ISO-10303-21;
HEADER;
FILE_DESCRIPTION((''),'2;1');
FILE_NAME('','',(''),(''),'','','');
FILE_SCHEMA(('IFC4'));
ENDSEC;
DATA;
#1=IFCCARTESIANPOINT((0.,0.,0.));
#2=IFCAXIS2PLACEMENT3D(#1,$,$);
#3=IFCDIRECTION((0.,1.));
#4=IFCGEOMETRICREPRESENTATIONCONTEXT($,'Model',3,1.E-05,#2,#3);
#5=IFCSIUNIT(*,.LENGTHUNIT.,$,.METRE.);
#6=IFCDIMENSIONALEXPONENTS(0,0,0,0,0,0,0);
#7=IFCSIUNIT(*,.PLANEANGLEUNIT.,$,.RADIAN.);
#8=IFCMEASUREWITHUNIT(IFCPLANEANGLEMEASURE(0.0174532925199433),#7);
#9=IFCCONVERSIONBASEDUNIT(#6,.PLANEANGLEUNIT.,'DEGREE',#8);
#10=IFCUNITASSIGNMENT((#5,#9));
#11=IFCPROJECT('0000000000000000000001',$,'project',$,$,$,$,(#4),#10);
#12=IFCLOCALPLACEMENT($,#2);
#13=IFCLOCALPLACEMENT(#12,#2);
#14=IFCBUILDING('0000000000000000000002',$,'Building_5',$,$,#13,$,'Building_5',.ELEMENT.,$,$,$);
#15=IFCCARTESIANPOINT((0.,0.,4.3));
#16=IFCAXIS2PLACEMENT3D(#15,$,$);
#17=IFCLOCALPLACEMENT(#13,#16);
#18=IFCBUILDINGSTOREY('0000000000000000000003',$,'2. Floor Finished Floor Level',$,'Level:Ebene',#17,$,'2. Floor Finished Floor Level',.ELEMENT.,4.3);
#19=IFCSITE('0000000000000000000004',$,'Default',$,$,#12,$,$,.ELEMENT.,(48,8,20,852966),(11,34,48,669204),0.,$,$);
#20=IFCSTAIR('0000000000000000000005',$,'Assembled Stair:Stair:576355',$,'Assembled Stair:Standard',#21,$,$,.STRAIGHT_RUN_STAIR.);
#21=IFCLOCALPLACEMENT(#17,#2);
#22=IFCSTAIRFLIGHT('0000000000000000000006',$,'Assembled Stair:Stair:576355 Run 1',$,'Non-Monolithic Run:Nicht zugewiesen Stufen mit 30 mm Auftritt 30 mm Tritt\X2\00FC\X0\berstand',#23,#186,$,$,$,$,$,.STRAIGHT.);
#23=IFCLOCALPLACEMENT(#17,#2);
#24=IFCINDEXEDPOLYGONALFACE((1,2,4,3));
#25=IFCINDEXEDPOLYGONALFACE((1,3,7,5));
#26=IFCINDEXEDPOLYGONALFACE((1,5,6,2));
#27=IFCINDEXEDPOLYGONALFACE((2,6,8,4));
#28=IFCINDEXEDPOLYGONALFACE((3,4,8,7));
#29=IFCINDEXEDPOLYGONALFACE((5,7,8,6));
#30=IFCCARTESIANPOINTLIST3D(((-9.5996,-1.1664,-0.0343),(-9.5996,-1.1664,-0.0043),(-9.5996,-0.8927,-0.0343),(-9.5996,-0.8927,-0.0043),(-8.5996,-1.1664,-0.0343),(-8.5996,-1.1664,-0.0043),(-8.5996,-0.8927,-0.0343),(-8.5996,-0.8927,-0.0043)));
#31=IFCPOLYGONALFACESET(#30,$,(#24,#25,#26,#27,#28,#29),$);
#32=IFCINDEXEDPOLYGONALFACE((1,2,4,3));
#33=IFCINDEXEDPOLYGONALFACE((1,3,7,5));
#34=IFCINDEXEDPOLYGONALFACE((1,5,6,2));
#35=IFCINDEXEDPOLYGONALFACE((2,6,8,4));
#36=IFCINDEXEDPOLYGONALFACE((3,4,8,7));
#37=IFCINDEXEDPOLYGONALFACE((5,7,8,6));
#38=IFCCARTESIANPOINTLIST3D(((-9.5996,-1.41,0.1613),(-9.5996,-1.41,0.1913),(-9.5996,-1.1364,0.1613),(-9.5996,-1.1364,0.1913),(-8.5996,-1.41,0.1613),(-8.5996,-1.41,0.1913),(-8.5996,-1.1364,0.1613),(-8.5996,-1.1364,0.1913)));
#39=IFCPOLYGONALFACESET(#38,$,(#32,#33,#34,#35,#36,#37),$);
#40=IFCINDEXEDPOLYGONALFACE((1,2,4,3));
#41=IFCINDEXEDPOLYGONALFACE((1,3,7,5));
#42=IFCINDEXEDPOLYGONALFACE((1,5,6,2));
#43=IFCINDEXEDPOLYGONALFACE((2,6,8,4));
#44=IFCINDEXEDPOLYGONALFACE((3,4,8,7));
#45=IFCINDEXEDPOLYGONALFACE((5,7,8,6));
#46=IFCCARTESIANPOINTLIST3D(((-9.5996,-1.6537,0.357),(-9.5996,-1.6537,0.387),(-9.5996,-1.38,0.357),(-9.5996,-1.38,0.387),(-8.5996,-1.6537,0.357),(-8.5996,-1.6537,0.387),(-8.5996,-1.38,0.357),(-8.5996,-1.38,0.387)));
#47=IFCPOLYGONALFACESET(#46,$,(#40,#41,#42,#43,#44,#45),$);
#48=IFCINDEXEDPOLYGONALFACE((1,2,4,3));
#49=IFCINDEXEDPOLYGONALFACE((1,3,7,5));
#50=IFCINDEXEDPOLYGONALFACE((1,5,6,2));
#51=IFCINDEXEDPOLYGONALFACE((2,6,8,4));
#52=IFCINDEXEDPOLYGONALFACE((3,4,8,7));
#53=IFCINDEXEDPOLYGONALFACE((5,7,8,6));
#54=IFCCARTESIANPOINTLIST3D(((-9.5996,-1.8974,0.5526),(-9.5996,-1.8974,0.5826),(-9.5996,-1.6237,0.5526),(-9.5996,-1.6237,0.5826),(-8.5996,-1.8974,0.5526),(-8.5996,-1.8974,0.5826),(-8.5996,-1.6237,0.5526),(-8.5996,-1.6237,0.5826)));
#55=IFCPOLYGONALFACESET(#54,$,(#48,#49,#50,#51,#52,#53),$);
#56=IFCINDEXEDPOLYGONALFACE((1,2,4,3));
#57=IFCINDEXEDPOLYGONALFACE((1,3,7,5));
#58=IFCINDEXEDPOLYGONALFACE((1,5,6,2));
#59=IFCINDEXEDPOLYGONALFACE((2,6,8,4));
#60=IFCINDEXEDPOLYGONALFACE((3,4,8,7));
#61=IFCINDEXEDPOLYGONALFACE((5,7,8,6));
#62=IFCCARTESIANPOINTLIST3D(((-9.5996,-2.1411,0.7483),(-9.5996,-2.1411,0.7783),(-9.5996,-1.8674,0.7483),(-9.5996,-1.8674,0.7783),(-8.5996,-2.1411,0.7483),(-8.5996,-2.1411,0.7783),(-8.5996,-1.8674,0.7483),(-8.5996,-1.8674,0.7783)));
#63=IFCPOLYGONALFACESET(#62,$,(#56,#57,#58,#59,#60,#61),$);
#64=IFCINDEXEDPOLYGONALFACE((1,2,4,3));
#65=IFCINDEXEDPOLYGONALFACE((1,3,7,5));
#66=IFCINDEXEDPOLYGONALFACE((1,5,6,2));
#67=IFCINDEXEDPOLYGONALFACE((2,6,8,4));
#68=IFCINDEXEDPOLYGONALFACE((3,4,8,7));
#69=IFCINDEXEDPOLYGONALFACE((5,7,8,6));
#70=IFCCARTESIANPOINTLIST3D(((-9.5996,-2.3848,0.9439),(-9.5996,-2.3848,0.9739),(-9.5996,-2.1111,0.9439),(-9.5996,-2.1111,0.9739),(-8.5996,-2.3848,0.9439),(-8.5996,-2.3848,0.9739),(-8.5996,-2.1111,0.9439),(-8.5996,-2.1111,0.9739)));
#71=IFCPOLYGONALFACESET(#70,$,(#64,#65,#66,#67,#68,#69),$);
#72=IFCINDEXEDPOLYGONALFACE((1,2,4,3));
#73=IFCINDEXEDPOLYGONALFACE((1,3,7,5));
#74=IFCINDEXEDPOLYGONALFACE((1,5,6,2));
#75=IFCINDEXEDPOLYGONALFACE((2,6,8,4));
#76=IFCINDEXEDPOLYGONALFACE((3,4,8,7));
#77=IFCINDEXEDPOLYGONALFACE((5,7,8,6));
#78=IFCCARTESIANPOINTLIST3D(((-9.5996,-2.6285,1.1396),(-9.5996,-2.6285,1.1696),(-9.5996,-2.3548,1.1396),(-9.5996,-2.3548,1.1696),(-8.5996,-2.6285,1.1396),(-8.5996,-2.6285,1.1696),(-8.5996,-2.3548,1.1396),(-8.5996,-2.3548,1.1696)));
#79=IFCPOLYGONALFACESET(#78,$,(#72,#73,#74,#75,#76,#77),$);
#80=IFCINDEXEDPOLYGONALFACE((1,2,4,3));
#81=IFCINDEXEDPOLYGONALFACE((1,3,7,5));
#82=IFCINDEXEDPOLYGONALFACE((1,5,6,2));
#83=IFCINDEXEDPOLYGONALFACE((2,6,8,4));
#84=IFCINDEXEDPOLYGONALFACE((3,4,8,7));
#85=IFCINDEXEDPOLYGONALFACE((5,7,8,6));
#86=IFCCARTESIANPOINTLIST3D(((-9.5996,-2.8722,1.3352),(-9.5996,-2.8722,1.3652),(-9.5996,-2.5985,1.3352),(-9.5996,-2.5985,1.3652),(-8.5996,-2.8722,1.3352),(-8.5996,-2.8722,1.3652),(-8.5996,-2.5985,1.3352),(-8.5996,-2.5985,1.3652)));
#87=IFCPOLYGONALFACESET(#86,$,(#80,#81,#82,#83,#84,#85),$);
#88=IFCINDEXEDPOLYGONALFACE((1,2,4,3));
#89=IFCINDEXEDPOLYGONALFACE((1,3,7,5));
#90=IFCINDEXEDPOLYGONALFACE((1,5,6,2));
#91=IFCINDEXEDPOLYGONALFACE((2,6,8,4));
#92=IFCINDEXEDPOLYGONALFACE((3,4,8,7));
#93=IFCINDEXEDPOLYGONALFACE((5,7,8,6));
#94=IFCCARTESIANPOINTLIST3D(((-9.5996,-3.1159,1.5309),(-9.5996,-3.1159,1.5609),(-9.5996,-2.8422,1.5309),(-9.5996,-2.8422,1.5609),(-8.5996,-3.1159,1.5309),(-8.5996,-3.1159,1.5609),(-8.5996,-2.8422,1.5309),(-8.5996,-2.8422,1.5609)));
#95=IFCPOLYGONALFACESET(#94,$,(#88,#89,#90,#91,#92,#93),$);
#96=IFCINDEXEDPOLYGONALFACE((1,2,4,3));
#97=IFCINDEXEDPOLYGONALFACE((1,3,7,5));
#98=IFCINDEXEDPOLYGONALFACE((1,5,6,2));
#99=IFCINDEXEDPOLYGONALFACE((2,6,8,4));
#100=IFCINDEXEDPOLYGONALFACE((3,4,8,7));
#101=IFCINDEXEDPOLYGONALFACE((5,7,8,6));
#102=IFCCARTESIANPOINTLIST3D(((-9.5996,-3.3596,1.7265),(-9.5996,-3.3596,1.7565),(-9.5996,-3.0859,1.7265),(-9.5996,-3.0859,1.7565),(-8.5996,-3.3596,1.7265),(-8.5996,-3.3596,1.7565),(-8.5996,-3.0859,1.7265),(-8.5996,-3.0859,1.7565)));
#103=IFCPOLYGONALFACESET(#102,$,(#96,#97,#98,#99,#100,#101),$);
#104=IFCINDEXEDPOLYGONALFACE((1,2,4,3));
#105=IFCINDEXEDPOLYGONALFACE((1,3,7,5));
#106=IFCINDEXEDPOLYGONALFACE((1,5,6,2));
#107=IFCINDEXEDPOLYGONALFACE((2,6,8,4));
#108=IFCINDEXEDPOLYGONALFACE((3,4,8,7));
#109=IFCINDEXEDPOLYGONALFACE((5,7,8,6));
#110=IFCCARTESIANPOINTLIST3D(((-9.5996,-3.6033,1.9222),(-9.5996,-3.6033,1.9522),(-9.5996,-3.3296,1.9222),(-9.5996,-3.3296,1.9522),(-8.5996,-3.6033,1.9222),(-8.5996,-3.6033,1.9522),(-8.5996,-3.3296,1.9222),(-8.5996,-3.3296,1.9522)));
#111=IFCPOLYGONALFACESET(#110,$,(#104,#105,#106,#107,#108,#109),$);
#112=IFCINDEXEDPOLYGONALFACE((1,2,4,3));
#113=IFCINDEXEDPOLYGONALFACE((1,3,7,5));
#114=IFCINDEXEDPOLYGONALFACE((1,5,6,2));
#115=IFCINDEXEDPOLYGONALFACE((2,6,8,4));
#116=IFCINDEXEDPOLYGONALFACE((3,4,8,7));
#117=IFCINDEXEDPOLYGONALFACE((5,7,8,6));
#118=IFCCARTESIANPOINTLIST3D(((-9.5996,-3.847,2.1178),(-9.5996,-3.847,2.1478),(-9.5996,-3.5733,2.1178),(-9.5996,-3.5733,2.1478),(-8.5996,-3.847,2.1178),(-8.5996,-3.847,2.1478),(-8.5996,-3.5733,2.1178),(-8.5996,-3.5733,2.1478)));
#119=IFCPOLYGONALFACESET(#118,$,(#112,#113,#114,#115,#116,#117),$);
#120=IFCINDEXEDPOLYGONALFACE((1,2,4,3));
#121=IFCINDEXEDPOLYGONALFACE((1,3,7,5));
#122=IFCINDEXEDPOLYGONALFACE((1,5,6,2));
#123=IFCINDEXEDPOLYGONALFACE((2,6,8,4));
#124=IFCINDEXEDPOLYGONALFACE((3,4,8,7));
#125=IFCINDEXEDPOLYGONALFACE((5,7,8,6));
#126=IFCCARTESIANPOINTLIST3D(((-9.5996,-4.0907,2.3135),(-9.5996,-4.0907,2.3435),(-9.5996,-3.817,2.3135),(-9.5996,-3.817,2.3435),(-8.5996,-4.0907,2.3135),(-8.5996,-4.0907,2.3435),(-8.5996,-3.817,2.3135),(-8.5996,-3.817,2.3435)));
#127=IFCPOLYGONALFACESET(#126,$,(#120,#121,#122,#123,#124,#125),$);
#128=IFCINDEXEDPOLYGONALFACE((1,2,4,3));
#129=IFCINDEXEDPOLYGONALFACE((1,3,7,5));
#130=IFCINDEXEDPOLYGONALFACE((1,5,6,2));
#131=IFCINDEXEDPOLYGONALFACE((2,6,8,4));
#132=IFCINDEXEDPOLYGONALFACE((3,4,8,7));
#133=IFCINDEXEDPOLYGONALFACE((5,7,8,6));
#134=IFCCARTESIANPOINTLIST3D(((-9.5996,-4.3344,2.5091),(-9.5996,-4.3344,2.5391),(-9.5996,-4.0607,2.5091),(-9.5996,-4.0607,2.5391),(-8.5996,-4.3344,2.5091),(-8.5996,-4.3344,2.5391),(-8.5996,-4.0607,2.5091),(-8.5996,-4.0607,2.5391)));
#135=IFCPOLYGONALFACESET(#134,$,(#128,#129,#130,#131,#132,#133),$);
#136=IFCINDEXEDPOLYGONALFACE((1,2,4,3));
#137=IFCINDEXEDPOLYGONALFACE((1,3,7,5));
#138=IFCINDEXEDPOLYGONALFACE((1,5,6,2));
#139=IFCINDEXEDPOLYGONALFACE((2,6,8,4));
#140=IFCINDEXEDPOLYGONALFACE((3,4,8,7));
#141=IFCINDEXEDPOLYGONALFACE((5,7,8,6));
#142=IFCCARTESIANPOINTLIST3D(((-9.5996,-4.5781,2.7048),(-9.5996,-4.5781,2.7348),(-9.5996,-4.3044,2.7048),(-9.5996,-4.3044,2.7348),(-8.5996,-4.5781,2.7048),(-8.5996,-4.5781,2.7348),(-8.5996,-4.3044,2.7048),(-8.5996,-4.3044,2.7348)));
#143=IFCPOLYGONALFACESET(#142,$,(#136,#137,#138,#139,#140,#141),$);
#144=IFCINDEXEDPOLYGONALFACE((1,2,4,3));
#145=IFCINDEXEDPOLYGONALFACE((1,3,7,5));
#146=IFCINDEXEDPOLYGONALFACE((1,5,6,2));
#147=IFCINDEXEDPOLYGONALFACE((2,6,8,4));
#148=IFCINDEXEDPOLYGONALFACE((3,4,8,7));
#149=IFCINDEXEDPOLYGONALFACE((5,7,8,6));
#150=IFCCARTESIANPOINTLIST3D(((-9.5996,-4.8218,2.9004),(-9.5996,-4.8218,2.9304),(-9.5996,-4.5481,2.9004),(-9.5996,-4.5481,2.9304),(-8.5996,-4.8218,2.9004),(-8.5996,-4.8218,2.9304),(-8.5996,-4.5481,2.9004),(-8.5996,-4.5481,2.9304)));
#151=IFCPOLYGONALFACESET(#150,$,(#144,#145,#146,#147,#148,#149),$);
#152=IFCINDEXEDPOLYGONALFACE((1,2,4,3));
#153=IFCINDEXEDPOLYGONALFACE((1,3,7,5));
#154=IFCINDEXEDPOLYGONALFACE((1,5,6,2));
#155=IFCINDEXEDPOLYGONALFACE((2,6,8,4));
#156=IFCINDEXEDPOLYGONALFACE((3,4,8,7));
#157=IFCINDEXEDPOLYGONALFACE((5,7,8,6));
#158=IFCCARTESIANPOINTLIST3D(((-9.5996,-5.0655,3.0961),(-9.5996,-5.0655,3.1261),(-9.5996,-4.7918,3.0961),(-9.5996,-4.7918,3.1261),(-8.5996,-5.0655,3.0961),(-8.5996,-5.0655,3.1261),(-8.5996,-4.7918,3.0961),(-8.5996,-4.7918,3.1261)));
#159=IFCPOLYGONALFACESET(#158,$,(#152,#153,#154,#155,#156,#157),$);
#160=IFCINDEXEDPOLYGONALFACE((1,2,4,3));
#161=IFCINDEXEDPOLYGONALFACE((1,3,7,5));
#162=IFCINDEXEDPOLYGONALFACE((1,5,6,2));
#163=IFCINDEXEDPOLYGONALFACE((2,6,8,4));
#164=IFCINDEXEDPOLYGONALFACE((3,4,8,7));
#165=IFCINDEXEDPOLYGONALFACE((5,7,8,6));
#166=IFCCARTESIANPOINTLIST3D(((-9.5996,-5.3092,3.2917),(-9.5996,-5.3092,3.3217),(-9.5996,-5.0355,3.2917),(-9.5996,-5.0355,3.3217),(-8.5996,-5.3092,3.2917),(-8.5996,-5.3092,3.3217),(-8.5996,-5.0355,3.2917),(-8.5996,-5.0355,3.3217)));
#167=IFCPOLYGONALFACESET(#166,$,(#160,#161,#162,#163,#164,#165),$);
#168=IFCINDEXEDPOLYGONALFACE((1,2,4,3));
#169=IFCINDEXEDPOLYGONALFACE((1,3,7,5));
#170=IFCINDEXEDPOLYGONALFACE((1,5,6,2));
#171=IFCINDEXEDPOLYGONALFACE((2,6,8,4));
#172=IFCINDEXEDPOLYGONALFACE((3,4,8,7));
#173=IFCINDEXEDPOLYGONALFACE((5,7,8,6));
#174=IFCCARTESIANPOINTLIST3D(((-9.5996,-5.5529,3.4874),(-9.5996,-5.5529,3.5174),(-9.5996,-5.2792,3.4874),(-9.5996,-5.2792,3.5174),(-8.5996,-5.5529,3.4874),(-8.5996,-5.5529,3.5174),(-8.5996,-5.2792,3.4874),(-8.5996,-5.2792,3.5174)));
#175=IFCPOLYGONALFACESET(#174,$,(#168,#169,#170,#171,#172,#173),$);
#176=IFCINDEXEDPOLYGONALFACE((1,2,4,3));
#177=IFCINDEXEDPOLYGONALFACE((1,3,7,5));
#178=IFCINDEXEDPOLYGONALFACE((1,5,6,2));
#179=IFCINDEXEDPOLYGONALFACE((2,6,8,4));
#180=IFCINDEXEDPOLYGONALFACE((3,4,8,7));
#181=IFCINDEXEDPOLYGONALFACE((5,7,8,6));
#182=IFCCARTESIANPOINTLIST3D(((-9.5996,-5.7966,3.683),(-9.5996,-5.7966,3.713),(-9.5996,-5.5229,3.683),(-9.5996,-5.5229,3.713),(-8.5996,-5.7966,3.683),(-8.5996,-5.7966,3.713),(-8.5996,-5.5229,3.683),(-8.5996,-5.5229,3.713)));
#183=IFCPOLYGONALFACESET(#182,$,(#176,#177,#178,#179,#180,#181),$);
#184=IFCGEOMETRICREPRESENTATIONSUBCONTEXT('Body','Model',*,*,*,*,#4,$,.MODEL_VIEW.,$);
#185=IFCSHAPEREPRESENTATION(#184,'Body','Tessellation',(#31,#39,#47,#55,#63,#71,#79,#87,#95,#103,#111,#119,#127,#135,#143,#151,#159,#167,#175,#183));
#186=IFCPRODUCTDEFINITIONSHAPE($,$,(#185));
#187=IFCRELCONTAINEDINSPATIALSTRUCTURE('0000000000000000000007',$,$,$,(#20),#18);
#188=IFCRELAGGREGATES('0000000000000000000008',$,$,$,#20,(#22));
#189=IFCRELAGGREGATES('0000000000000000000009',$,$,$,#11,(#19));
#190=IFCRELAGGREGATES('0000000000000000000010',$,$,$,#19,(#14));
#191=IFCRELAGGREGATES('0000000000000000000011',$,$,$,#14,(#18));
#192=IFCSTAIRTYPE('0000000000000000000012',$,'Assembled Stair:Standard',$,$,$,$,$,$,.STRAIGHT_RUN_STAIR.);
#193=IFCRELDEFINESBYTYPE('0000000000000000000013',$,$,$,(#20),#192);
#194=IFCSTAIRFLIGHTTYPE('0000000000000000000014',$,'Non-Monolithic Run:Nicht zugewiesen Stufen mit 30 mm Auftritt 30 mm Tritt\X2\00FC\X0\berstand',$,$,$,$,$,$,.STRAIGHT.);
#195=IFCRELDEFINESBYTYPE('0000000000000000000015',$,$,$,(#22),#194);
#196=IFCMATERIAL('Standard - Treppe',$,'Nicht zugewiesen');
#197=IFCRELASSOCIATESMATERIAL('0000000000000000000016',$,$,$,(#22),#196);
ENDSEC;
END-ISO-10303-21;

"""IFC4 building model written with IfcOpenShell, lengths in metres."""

from ifc_helpers import new_model, entity, si_unit, converted_unit, direction, frame, origin, place, context, subcontext, project, spatial, indexed_curve, outline, extrude, material, type_object, element, aggregate, save


model = new_model("IFC4")

# Units and contexts
model_context = context("Model", 3, precision=1e-05, world=origin(), true_north=direction((0.0, 1.0)))
body_context = subcontext(model_context, "Body", "Model", "MODEL_VIEW")
ifc_project = project(units=[si_unit("LENGTHUNIT", "METRE"), converted_unit("PLANEANGLEUNIT", "DEGREE", entity("IfcPlaneAngleMeasure", 0.0174532925199433), si_unit("PLANEANGLEUNIT", "RADIAN"), dimensions=[0, 0, 0, 0, 0, 0, 0])], contexts=[model_context])

# Site, building, storey
site_placement = place(None, origin())
site = spatial("IfcSite", under=ifc_project, at=site_placement, Name="Default", CompositionType="ELEMENT", RefLatitude=(48, 8, 20, 852966), RefLongitude=(11, 34, 48, 669204), RefElevation=0.0)
building_placement = place(site_placement, origin())
building = spatial("IfcBuilding", under=site, at=building_placement, Name="Building_5", LongName="Building_5", CompositionType="ELEMENT")
storey_placement = place(building_placement, frame((0.0, 0.0, 4.3)))
storey = spatial("IfcBuildingStorey", under=building, at=storey_placement, Name="2. Floor Finished Floor Level", ObjectType="Level:Ebene", LongName="2. Floor Finished Floor Level", CompositionType="ELEMENT", Elevation=4.3)

# Stair, stair flight
stair_type_1 = type_object("IfcStairType", Name="Assembled Stair:Standard", PredefinedType="STRAIGHT_RUN_STAIR")
stair_1_placement = place(storey_placement, origin())
stair_1 = element("IfcStair", 1, at=stair_1_placement, inside=storey, type_object=stair_type_1, Name="Assembled Stair:Stair:576355", ObjectType="Assembled Stair:Standard", PredefinedType="STRAIGHT_RUN_STAIR")
ifc_material_1 = material(Name="Standard - Treppe", Category="Nicht zugewiesen")
stair_flight_type_1 = type_object("IfcStairFlightType", Name="Non-Monolithic Run:Nicht zugewiesen Stufen mit 30 mm Auftritt 30 mm Trittüberstand", PredefinedType="STRAIGHT")
stair_flight_1_placement = place(stair_1_placement, origin())
stair_flight_1 = element("IfcStairFlight", 2, at=stair_flight_1_placement, type_object=stair_flight_type_1, material=ifc_material_1, Name="Assembled Stair:Stair:576355 Run 1", ObjectType="Non-Monolithic Run:Nicht zugewiesen Stufen mit 30 mm Auftritt 30 mm Trittüberstand", PredefinedType="STRAIGHT", context=body_context, shape_type="SweptSolid", body=[
    extrude(outline(indexed_curve([(-0.1368, -0.5), (0.1368, -0.5), (0.1368, 0.5), (-0.1368, 0.5), (-0.1368, -0.5)], self_intersect=False)), frame((-9.0996, -1.0295, -0.0343), z_axis=(0.0, 0.0, 1.0), x_axis=(0.0, 1.0, 0.0)), (0.0, 0.0, 1.0), 0.03),
    extrude(outline(indexed_curve([(-0.1368, -0.5), (0.1368, -0.5), (0.1368, 0.5), (-0.1368, 0.5), (-0.1368, -0.5)], self_intersect=False)), frame((-9.0996, -1.2732, 0.1613), z_axis=(0.0, 0.0, 1.0), x_axis=(0.0, 1.0, 0.0)), (0.0, 0.0, 1.0), 0.03),
    extrude(outline(indexed_curve([(-0.1368, -0.5), (0.1368, -0.5), (0.1368, 0.5), (-0.1368, 0.5), (-0.1368, -0.5)], self_intersect=False)), frame((-9.0996, -1.5169, 0.357), z_axis=(0.0, 0.0, 1.0), x_axis=(0.0, 1.0, 0.0)), (0.0, 0.0, 1.0), 0.03),
    extrude(outline(indexed_curve([(-0.1368, -0.5), (0.1368, -0.5), (0.1368, 0.5), (-0.1368, 0.5), (-0.1368, -0.5)], self_intersect=False)), frame((-9.0996, -1.7606, 0.5526), z_axis=(0.0, 0.0, 1.0), x_axis=(0.0, 1.0, 0.0)), (0.0, 0.0, 1.0), 0.03),
    extrude(outline(indexed_curve([(-0.1368, -0.5), (0.1368, -0.5), (0.1368, 0.5), (-0.1368, 0.5), (-0.1368, -0.5)], self_intersect=False)), frame((-9.0996, -2.0043, 0.7483), z_axis=(0.0, 0.0, 1.0), x_axis=(0.0, 1.0, 0.0)), (0.0, 0.0, 1.0), 0.03),
    extrude(outline(indexed_curve([(-0.1368, -0.5), (0.1368, -0.5), (0.1368, 0.5), (-0.1368, 0.5), (-0.1368, -0.5)], self_intersect=False)), frame((-9.0996, -2.248, 0.9439), z_axis=(0.0, 0.0, 1.0), x_axis=(0.0, 1.0, 0.0)), (0.0, 0.0, 1.0), 0.03),
    extrude(outline(indexed_curve([(-0.1368, -0.5), (0.1368, -0.5), (0.1368, 0.5), (-0.1368, 0.5), (-0.1368, -0.5)], self_intersect=False)), frame((-9.0996, -2.4917, 1.1396), z_axis=(0.0, 0.0, 1.0), x_axis=(0.0, 1.0, 0.0)), (0.0, 0.0, 1.0), 0.03),
    extrude(outline(indexed_curve([(-0.1368, -0.5), (0.1368, -0.5), (0.1368, 0.5), (-0.1368, 0.5), (-0.1368, -0.5)], self_intersect=False)), frame((-9.0996, -2.7354, 1.3352), z_axis=(0.0, 0.0, 1.0), x_axis=(0.0, 1.0, 0.0)), (0.0, 0.0, 1.0), 0.03),
    extrude(outline(indexed_curve([(-0.1368, -0.5), (0.1368, -0.5), (0.1368, 0.5), (-0.1368, 0.5), (-0.1368, -0.5)], self_intersect=False)), frame((-9.0996, -2.9791, 1.5309), z_axis=(0.0, 0.0, 1.0), x_axis=(0.0, 1.0, 0.0)), (0.0, 0.0, 1.0), 0.03),
    extrude(outline(indexed_curve([(-0.1368, -0.5), (0.1368, -0.5), (0.1368, 0.5), (-0.1368, 0.5), (-0.1368, -0.5)], self_intersect=False)), frame((-9.0996, -3.2228, 1.7265), z_axis=(0.0, 0.0, 1.0), x_axis=(0.0, 1.0, 0.0)), (0.0, 0.0, 1.0), 0.03),
    extrude(outline(indexed_curve([(-0.1368, -0.5), (0.1368, -0.5), (0.1368, 0.5), (-0.1368, 0.5), (-0.1368, -0.5)], self_intersect=False)), frame((-9.0996, -3.4665, 1.9222), z_axis=(0.0, 0.0, 1.0), x_axis=(0.0, 1.0, 0.0)), (0.0, 0.0, 1.0), 0.03),
    extrude(outline(indexed_curve([(-0.1368, -0.5), (0.1368, -0.5), (0.1368, 0.5), (-0.1368, 0.5), (-0.1368, -0.5)], self_intersect=False)), frame((-9.0996, -3.7102, 2.1178), z_axis=(0.0, 0.0, 1.0), x_axis=(0.0, 1.0, 0.0)), (0.0, 0.0, 1.0), 0.03),
    extrude(outline(indexed_curve([(-0.1368, -0.5), (0.1368, -0.5), (0.1368, 0.5), (-0.1368, 0.5), (-0.1368, -0.5)], self_intersect=False)), frame((-9.0996, -3.9539, 2.3135), z_axis=(0.0, 0.0, 1.0), x_axis=(0.0, 1.0, 0.0)), (0.0, 0.0, 1.0), 0.03),
    extrude(outline(indexed_curve([(-0.1368, -0.5), (0.1368, -0.5), (0.1368, 0.5), (-0.1368, 0.5), (-0.1368, -0.5)], self_intersect=False)), frame((-9.0996, -4.1975, 2.5091), z_axis=(0.0, 0.0, 1.0), x_axis=(0.0, 1.0, 0.0)), (0.0, 0.0, 1.0), 0.03),
    extrude(outline(indexed_curve([(-0.1368, -0.5), (0.1368, -0.5), (0.1368, 0.5), (-0.1368, 0.5), (-0.1368, -0.5)], self_intersect=False)), frame((-9.0996, -4.4412, 2.7048), z_axis=(0.0, 0.0, 1.0), x_axis=(0.0, 1.0, 0.0)), (0.0, 0.0, 1.0), 0.03),
    extrude(outline(indexed_curve([(-0.1368, -0.5), (0.1368, -0.5), (0.1368, 0.5), (-0.1368, 0.5), (-0.1368, -0.5)], self_intersect=False)), frame((-9.0996, -4.6849, 2.9004), z_axis=(0.0, 0.0, 1.0), x_axis=(0.0, 1.0, 0.0)), (0.0, 0.0, 1.0), 0.03),
    extrude(outline(indexed_curve([(-0.1368, -0.5), (0.1368, -0.5), (0.1368, 0.5), (-0.1368, 0.5), (-0.1368, -0.5)], self_intersect=False)), frame((-9.0996, -4.9286, 3.0961), z_axis=(0.0, 0.0, 1.0), x_axis=(0.0, 1.0, 0.0)), (0.0, 0.0, 1.0), 0.03),
    extrude(outline(indexed_curve([(-0.1368, -0.5), (0.1368, -0.5), (0.1368, 0.5), (-0.1368, 0.5), (-0.1368, -0.5)], self_intersect=False)), frame((-9.0996, -5.1723, 3.2917), z_axis=(0.0, 0.0, 1.0), x_axis=(0.0, 1.0, 0.0)), (0.0, 0.0, 1.0), 0.03),
    extrude(outline(indexed_curve([(-0.1368, -0.5), (0.1368, -0.5), (0.1368, 0.5), (-0.1368, 0.5), (-0.1368, -0.5)], self_intersect=False)), frame((-9.0996, -5.416, 3.4874), z_axis=(0.0, 0.0, 1.0), x_axis=(0.0, 1.0, 0.0)), (0.0, 0.0, 1.0), 0.03),
    extrude(outline(indexed_curve([(-0.1368, -0.5), (0.1368, -0.5), (0.1368, 0.5), (-0.1368, 0.5), (-0.1368, -0.5)], self_intersect=False)), frame((-9.0996, -5.6597, 3.683), z_axis=(0.0, 0.0, 1.0), x_axis=(0.0, 1.0, 0.0)), (0.0, 0.0, 1.0), 0.03),
])
aggregate(stair_1, [stair_flight_1])

save(model, "model.ifc")
